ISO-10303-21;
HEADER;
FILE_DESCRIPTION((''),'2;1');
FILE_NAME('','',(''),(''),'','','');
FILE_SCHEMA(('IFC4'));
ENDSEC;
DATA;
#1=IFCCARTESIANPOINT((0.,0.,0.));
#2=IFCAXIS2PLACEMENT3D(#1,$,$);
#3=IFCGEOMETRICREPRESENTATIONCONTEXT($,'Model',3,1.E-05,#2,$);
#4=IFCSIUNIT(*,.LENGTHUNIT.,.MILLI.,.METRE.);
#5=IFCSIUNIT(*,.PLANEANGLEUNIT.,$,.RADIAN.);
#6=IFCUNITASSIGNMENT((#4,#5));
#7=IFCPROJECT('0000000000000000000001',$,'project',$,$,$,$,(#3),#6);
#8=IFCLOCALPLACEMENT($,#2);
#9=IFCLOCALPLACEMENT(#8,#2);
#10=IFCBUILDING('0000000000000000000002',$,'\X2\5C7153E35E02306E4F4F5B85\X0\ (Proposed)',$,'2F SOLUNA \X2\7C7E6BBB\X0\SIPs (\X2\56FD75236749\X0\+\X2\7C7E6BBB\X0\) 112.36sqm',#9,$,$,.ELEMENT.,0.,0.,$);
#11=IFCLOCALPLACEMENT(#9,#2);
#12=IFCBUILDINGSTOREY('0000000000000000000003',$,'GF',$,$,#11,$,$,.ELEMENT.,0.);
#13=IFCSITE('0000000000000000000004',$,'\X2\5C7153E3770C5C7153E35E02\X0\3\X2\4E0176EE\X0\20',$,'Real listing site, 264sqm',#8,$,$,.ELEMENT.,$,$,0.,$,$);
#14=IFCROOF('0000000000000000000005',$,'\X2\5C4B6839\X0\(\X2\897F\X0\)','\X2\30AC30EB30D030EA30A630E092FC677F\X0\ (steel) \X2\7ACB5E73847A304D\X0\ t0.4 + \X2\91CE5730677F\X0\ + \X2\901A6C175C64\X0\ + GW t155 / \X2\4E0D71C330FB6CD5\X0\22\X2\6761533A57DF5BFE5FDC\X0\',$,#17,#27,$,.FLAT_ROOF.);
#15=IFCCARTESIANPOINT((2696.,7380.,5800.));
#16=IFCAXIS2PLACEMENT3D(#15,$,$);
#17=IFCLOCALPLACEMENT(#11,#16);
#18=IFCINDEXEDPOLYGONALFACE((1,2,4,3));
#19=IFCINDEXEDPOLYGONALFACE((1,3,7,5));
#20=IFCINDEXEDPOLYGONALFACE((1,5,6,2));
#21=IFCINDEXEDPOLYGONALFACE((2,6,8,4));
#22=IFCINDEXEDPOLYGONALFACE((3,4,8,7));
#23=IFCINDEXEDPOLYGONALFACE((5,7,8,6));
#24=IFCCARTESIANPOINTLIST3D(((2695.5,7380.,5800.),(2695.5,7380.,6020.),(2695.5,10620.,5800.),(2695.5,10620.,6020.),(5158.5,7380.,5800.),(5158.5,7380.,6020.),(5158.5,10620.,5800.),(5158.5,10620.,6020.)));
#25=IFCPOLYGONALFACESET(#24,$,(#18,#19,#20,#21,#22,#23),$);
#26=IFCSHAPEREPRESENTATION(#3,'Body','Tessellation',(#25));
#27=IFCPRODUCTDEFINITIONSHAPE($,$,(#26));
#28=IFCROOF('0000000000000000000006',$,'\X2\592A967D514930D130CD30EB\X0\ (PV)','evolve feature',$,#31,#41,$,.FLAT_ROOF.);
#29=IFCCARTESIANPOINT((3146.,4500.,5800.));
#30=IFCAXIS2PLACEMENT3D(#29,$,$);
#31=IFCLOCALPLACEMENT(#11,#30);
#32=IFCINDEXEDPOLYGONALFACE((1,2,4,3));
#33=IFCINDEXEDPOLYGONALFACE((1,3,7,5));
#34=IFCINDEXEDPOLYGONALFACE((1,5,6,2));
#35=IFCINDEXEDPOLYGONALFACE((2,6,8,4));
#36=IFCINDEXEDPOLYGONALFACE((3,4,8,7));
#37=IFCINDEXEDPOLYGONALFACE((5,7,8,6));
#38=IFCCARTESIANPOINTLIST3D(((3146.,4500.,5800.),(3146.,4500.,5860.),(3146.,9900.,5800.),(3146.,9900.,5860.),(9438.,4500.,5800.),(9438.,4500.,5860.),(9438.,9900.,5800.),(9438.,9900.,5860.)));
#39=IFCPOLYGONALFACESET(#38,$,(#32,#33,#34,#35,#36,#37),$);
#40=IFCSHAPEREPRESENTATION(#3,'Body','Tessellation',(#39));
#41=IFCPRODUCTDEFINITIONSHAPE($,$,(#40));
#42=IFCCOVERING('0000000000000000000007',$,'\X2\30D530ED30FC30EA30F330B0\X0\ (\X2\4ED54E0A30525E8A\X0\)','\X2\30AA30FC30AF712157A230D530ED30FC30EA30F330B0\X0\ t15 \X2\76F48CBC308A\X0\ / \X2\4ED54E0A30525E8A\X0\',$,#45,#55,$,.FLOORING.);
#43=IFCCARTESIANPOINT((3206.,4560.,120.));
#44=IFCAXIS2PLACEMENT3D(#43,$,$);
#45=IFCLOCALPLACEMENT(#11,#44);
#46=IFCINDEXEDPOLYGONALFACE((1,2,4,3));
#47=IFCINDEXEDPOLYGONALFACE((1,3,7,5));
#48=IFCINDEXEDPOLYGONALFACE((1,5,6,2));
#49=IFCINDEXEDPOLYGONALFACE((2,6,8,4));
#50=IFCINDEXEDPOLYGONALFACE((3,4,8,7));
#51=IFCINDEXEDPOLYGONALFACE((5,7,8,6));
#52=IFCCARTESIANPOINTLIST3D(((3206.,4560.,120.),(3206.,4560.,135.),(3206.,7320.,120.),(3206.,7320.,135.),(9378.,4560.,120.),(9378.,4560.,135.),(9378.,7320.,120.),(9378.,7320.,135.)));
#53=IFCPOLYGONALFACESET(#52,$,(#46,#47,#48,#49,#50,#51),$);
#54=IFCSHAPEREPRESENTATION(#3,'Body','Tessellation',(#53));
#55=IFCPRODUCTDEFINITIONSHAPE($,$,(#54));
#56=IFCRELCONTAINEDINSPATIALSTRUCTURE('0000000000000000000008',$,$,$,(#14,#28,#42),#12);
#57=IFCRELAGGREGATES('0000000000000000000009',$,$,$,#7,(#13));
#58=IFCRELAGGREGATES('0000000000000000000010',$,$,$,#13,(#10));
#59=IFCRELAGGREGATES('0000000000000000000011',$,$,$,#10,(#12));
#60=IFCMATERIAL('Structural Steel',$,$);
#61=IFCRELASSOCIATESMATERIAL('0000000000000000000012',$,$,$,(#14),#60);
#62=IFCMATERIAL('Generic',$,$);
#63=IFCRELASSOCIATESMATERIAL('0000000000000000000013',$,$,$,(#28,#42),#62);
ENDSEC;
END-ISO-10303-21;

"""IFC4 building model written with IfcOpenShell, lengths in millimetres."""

from ifc_helpers import new_model, si_unit, frame, frame_2d, origin, place, context, project, spatial, rectangle, extrude, material, element, save


model = new_model("IFC4")

# Units and contexts
model_context = context("Model", 3, precision=1e-05, world=origin())
ifc_project = project(units=[si_unit("LENGTHUNIT", "METRE", prefix="MILLI"), si_unit("PLANEANGLEUNIT", "RADIAN")], contexts=[model_context])

# Site, building, storey
site_placement = place(None, origin())
site = spatial("IfcSite", under=ifc_project, at=site_placement, Name="山口県山口市3丁目20", ObjectType="Real listing site, 264sqm", CompositionType="ELEMENT", RefElevation=0.0)
building_placement = place(site_placement, origin())
building = spatial("IfcBuilding", under=site, at=building_placement, Name="山口市の住宅 (Proposed)", ObjectType="2F SOLUNA 籾殻SIPs (国産杉+籾殻) 112.36sqm", CompositionType="ELEMENT", ElevationOfRefHeight=0.0, ElevationOfTerrain=0.0)
storey_placement = place(building_placement, origin())
storey = spatial("IfcBuildingStorey", under=building, at=storey_placement, Name="GF", CompositionType="ELEMENT", Elevation=0.0)

# Shared definitions
ifc_material_1 = material(Name="Generic")

# Roofs
ifc_material_2 = material(Name="Structural Steel")
roof_1_placement = place(storey_placement, frame((2696.0, 7380.0, 5800.0)))
element("IfcRoof", 1, at=roof_1_placement, inside=storey, material=ifc_material_2, Name="屋根(西)", Description="ガルバリウム鋼板 (steel) 立平葺き t0.4 + 野地板 + 通気層 + GW t155 / 不燃・法22条区域対応", PredefinedType="FLAT_ROOF", context=model_context, shape_type="SweptSolid", body=[
    extrude(rectangle(XDim=2463.0, YDim=3240.0, at=frame_2d((1231.0, 1620.0))), frame((2696.0, 7380.0, 5800.0)), (0.0, 0.0, 1.0), 220.0),
])
roof_2_placement = place(storey_placement, frame((3146.0, 4500.0, 5800.0)))
element("IfcRoof", 2, at=roof_2_placement, inside=storey, material=ifc_material_1, Name="太陽光パネル (PV)", Description="evolve feature", PredefinedType="FLAT_ROOF", context=model_context, shape_type="SweptSolid", body=[
    extrude(rectangle(XDim=6292.0, YDim=5400.0, at=frame_2d((3146.0, 2700.0))), frame((3146.0, 4500.0, 5800.0)), (0.0, 0.0, 1.0), 60.0),
])

# Covering
covering_placement = place(storey_placement, frame((3206.0, 4560.0, 120.0)))
element("IfcCovering", 3, at=covering_placement, inside=storey, material=ifc_material_1, Name="フローリング (仕上げ床)", Description="オーク無垢フローリング t15 直貼り / 仕上げ床", PredefinedType="FLOORING", context=model_context, shape_type="SweptSolid", body=[
    extrude(rectangle(XDim=6172.0, YDim=2760.0, at=frame_2d((3086.0, 1380.0))), frame((3206.0, 4560.0, 120.0)), (0.0, 0.0, 1.0), 15.0),
])

save(model, "model.ifc")
